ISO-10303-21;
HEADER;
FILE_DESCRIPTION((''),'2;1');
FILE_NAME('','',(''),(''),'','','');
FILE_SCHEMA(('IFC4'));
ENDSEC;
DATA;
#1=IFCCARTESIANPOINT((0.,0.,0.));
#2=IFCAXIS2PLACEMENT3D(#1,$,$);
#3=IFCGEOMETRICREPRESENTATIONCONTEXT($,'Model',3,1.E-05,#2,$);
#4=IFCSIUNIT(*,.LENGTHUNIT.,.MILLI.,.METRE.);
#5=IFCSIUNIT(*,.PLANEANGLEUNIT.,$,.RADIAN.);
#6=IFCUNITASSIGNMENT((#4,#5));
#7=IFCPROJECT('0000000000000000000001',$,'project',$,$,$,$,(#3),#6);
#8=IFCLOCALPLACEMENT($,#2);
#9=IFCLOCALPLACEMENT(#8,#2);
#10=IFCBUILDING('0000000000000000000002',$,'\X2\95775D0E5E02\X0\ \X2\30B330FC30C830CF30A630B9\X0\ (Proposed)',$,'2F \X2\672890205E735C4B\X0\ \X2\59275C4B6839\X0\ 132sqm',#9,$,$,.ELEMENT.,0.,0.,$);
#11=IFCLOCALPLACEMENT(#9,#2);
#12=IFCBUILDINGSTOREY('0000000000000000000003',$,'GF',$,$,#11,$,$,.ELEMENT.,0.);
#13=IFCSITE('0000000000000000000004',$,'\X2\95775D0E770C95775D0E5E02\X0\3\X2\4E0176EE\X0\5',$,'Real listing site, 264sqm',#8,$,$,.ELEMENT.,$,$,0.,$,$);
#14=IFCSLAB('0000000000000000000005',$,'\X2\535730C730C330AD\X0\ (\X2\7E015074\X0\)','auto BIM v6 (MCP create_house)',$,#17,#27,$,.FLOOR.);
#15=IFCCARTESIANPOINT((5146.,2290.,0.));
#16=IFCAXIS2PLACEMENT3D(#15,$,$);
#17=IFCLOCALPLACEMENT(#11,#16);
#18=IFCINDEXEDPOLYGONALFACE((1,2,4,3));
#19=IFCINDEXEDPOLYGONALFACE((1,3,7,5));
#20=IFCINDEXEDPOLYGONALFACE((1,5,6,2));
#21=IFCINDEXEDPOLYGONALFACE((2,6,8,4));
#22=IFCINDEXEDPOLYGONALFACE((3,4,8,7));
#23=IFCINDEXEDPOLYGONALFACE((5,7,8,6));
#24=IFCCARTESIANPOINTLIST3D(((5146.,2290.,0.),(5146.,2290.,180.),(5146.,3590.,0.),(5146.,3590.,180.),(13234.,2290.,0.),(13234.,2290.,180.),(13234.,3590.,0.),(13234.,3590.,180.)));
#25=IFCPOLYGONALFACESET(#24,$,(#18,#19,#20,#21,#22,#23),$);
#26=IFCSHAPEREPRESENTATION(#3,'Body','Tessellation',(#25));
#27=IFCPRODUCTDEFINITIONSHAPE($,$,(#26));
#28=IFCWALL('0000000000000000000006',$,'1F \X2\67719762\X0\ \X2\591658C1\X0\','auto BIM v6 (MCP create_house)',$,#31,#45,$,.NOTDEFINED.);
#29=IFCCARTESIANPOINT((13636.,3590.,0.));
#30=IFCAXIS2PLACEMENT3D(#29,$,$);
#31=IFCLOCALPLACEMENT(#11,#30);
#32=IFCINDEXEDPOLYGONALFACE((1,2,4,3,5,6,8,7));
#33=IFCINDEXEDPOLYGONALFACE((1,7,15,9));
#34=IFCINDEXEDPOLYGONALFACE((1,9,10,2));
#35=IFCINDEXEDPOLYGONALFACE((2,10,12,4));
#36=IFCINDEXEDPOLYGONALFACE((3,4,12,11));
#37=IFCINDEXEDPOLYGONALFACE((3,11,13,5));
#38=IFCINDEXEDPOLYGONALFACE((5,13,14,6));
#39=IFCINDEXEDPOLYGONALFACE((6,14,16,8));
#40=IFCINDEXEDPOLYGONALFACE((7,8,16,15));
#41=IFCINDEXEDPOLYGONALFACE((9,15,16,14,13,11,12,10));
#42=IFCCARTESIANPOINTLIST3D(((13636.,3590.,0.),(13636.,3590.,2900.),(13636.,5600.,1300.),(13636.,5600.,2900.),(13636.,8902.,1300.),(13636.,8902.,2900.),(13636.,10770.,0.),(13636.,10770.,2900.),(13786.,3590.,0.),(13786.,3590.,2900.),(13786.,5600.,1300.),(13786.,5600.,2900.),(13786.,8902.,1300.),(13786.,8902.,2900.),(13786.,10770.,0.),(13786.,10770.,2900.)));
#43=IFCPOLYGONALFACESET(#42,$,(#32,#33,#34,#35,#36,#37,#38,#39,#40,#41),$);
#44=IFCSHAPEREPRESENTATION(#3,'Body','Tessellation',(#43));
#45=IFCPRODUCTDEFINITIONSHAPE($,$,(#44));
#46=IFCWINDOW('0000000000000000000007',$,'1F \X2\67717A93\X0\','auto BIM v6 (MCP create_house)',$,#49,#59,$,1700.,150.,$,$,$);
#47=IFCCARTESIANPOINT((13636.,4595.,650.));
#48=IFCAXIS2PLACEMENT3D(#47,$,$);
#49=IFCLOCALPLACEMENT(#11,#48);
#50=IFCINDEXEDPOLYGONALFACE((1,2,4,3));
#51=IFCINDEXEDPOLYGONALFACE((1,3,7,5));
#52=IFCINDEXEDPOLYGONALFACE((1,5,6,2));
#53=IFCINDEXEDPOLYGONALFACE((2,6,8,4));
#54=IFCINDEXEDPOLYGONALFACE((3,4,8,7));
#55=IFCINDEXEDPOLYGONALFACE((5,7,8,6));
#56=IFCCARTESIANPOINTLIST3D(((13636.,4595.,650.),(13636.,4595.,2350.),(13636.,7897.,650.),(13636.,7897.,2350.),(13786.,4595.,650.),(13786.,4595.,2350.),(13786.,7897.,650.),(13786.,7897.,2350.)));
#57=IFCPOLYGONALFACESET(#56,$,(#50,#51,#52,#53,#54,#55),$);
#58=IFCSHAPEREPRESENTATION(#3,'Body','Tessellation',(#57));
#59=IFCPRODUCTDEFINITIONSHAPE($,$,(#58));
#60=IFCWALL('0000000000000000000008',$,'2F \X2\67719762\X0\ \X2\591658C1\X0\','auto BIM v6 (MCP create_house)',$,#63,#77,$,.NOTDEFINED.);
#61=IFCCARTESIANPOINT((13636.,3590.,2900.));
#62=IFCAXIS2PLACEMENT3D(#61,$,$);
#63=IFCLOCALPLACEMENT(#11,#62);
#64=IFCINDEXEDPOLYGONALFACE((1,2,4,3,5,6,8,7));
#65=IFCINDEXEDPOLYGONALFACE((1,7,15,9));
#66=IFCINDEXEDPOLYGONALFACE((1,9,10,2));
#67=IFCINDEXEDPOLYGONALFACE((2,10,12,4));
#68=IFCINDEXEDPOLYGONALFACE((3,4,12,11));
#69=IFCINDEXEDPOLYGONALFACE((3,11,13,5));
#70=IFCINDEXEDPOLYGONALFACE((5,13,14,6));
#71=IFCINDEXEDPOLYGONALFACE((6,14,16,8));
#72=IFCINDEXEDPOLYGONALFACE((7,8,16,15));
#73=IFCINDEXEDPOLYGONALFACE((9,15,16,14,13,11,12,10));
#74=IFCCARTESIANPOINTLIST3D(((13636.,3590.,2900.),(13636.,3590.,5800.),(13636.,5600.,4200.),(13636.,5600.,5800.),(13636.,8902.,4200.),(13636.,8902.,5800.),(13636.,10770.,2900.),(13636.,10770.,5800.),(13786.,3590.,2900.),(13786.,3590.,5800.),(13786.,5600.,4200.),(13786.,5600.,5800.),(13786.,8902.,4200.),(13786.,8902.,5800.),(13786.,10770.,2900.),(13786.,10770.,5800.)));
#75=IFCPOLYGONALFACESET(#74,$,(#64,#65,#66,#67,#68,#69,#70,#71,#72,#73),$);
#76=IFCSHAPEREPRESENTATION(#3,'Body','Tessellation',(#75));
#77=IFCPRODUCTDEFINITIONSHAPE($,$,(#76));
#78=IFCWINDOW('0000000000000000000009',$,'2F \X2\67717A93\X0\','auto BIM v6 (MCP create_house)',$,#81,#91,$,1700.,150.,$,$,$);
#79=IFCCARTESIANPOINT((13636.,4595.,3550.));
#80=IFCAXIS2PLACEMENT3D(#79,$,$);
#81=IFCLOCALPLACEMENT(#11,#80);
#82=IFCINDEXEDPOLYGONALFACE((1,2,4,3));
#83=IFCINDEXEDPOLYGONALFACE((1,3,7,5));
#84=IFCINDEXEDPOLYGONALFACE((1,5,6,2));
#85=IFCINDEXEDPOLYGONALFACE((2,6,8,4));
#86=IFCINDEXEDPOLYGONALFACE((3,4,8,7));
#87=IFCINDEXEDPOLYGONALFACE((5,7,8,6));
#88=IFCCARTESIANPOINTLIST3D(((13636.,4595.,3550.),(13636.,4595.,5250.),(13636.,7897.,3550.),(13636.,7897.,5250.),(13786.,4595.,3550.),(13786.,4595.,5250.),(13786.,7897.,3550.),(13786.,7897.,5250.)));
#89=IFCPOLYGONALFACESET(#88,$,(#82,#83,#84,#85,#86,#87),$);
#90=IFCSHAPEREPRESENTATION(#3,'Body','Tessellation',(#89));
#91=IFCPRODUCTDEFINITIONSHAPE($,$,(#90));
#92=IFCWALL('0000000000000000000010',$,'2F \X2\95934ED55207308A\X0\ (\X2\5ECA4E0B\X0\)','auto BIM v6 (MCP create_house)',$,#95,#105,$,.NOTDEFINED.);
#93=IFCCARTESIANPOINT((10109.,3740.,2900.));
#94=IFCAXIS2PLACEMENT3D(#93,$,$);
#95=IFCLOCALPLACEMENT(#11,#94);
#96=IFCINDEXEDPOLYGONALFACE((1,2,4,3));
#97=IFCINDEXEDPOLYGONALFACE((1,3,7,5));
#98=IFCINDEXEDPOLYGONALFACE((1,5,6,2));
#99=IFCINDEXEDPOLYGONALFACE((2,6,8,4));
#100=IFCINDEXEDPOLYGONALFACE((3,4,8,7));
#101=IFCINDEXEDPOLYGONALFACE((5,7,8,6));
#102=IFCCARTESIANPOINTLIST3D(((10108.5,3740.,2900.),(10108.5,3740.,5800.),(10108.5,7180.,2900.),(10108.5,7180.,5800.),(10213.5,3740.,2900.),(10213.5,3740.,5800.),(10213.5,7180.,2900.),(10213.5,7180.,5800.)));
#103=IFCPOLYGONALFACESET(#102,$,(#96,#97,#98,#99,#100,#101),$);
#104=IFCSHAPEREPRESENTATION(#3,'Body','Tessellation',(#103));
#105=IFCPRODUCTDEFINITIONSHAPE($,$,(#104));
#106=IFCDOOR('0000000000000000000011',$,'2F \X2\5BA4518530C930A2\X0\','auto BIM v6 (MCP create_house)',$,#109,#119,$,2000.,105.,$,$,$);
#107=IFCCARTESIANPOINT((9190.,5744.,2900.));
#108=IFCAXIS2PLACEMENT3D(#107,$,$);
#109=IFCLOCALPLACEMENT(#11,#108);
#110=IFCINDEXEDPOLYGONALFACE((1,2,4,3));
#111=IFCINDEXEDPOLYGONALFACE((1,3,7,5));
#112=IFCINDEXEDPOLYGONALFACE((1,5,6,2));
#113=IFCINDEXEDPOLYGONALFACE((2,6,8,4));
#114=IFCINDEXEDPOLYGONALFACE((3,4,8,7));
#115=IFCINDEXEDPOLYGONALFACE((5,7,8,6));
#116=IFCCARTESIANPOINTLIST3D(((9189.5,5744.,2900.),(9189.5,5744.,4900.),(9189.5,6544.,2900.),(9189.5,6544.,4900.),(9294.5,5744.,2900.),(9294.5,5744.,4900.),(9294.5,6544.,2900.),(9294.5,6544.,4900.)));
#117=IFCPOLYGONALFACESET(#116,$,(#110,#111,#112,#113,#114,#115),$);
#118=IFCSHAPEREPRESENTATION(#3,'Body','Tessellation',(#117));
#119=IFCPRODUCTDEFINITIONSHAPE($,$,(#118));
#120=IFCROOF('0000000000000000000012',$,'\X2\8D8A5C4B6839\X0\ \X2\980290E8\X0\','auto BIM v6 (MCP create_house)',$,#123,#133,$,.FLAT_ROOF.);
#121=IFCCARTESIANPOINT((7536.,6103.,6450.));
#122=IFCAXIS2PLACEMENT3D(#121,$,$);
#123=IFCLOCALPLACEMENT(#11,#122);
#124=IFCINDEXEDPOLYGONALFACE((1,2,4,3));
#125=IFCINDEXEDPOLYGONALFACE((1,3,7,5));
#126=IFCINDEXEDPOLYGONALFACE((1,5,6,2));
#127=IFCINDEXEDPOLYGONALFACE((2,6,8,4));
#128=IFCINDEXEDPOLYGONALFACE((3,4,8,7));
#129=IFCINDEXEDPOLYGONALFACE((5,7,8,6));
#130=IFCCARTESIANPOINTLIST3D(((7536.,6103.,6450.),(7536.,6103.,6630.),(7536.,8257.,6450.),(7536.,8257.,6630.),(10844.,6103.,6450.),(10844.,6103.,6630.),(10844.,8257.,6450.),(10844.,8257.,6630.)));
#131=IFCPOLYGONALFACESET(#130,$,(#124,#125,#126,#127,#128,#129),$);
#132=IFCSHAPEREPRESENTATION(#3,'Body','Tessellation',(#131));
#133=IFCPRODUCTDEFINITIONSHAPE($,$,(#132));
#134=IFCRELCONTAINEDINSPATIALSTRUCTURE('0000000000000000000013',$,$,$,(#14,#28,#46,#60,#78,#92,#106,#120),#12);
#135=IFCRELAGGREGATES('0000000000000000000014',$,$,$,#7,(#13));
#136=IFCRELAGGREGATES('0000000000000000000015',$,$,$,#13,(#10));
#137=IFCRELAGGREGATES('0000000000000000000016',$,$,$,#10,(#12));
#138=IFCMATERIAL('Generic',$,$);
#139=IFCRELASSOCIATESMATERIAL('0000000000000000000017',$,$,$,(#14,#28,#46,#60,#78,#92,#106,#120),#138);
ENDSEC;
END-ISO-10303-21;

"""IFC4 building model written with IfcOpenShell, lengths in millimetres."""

from ifc_helpers import new_model, si_unit, frame, frame_2d, origin, place, context, project, spatial, rectangle, extrude, material, element, fill, save


model = new_model("IFC4")

# Units and contexts
model_context = context("Model", 3, precision=1e-05, world=origin())
ifc_project = project(units=[si_unit("LENGTHUNIT", "METRE", prefix="MILLI"), si_unit("PLANEANGLEUNIT", "RADIAN")], contexts=[model_context])

# Site, building, storey
site_placement = place(None, origin())
site = spatial("IfcSite", under=ifc_project, at=site_placement, Name="長崎県長崎市3丁目5", ObjectType="Real listing site, 264sqm", CompositionType="ELEMENT", RefElevation=0.0)
building_placement = place(site_placement, origin())
building = spatial("IfcBuilding", under=site, at=building_placement, Name="長崎市 コートハウス (Proposed)", ObjectType="2F 木造平屋 大屋根 132sqm", CompositionType="ELEMENT", ElevationOfRefHeight=0.0, ElevationOfTerrain=0.0)
storey_placement = place(building_placement, origin())
storey = spatial("IfcBuildingStorey", under=building, at=storey_placement, Name="GF", CompositionType="ELEMENT", Elevation=0.0)

# Slab
ifc_material = material(Name="Generic")
slab_placement = place(storey_placement, frame((5146.0, 2290.0, 0.0)))
element("IfcSlab", 1, at=slab_placement, inside=storey, material=ifc_material, Name="南デッキ (縁側)", Description="auto BIM v6 (MCP create_house)", PredefinedType="FLOOR", context=model_context, shape_type="SweptSolid", body=[
    extrude(rectangle(XDim=8088.0, YDim=1300.0, at=frame_2d((4044.0, 650.0))), frame((5146.0, 2290.0, 0.0)), (0.0, 0.0, 1.0), 180.0),
])

# Wall, opening, window
wall_1_placement = place(storey_placement, frame((13636.0, 3590.0, 0.0)))
wall_1 = element("IfcWall", 2, at=wall_1_placement, inside=storey, material=ifc_material, Name="1F 東面 外壁", Description="auto BIM v6 (MCP create_house)", PredefinedType="NOTDEFINED", context=model_context, shape_type="SweptSolid", body=[
    extrude(rectangle(XDim=150.0, YDim=7180.0, at=frame_2d((75.0, 3590.0))), frame((13636.0, 3590.0, 0.0)), (0.0, 0.0, 1.0), 2900.0),
])
opening_1_placement = place(storey_placement, frame((13636.0, 4595.0, 650.0)))
opening_1 = element("IfcOpeningElement", 3, at=opening_1_placement, cuts=wall_1, PredefinedType="NOTDEFINED", context=model_context, shape_type="SweptSolid", body=[
    extrude(rectangle(XDim=150.0, YDim=3302.0, at=frame_2d((75.0, 1651.0))), frame((13636.0, 4595.0, 650.0)), (0.0, 0.0, 1.0), 1700.0),
])
window_1_placement = place(storey_placement, frame((13636.0, 4595.0, 650.0)))
window_1 = element("IfcWindow", 4, at=window_1_placement, inside=storey, material=ifc_material, Name="1F 東窓", Description="auto BIM v6 (MCP create_house)", OverallHeight=1700.0, OverallWidth=150.0, context=model_context, shape_type="SweptSolid", body=[
    extrude(rectangle(XDim=150.0, YDim=3302.0, at=frame_2d((75.0, 1651.0))), frame((13636.0, 4595.0, 650.0)), (0.0, 0.0, 1.0), 1700.0),
])
fill(opening_1, window_1)

# Wall, opening, window
wall_2_placement = place(storey_placement, frame((13636.0, 3590.0, 2900.0)))
wall_2 = element("IfcWall", 5, at=wall_2_placement, inside=storey, material=ifc_material, Name="2F 東面 外壁", Description="auto BIM v6 (MCP create_house)", PredefinedType="NOTDEFINED", context=model_context, shape_type="SweptSolid", body=[
    extrude(rectangle(XDim=150.0, YDim=7180.0, at=frame_2d((75.0, 3590.0))), frame((13636.0, 3590.0, 2900.0)), (0.0, 0.0, 1.0), 2900.0),
])
opening_2_placement = place(storey_placement, frame((13636.0, 4595.0, 3550.0)))
opening_2 = element("IfcOpeningElement", 6, at=opening_2_placement, cuts=wall_2, PredefinedType="NOTDEFINED", context=model_context, shape_type="SweptSolid", body=[
    extrude(rectangle(XDim=150.0, YDim=3302.0, at=frame_2d((75.0, 1651.0))), frame((13636.0, 4595.0, 3550.0)), (0.0, 0.0, 1.0), 1700.0),
])
window_2_placement = place(storey_placement, frame((13636.0, 4595.0, 3550.0)))
window_2 = element("IfcWindow", 7, at=window_2_placement, inside=storey, material=ifc_material, Name="2F 東窓", Description="auto BIM v6 (MCP create_house)", OverallHeight=1700.0, OverallWidth=150.0, context=model_context, shape_type="SweptSolid", body=[
    extrude(rectangle(XDim=150.0, YDim=3302.0, at=frame_2d((75.0, 1651.0))), frame((13636.0, 4595.0, 3550.0)), (0.0, 0.0, 1.0), 1700.0),
])
fill(opening_2, window_2)

# Wall
wall_3_placement = place(storey_placement, frame((10109.0, 3740.0, 2900.0)))
element("IfcWall", 8, at=wall_3_placement, inside=storey, material=ifc_material, Name="2F 間仕切り (廊下)", Description="auto BIM v6 (MCP create_house)", PredefinedType="NOTDEFINED", context=model_context, shape_type="SweptSolid", body=[
    extrude(rectangle(XDim=105.0, YDim=3440.0, at=frame_2d((52.0, 1720.0))), frame((10109.0, 3740.0, 2900.0)), (0.0, 0.0, 1.0), 2900.0),
])

# Door
door_placement = place(storey_placement, frame((9190.0, 5744.0, 2900.0)))
element("IfcDoor", 9, at=door_placement, inside=storey, material=ifc_material, Name="2F 室内ドア", Description="auto BIM v6 (MCP create_house)", OverallHeight=2000.0, OverallWidth=105.0, context=model_context, shape_type="SweptSolid", body=[
    extrude(rectangle(XDim=105.0, YDim=800.0, at=frame_2d((52.0, 400.0))), frame((9190.0, 5744.0, 2900.0)), (0.0, 0.0, 1.0), 2000.0),
])

# Roof
roof_placement = place(storey_placement, frame((7536.0, 6103.0, 6450.0)))
element("IfcRoof", 10, at=roof_placement, inside=storey, material=ifc_material, Name="越屋根 頂部", Description="auto BIM v6 (MCP create_house)", PredefinedType="FLAT_ROOF", context=model_context, shape_type="SweptSolid", body=[
    extrude(rectangle(XDim=3308.0, YDim=2154.0, at=frame_2d((1654.0, 1077.0))), frame((7536.0, 6103.0, 6450.0)), (0.0, 0.0, 1.0), 180.0),
])

save(model, "model.ifc")
